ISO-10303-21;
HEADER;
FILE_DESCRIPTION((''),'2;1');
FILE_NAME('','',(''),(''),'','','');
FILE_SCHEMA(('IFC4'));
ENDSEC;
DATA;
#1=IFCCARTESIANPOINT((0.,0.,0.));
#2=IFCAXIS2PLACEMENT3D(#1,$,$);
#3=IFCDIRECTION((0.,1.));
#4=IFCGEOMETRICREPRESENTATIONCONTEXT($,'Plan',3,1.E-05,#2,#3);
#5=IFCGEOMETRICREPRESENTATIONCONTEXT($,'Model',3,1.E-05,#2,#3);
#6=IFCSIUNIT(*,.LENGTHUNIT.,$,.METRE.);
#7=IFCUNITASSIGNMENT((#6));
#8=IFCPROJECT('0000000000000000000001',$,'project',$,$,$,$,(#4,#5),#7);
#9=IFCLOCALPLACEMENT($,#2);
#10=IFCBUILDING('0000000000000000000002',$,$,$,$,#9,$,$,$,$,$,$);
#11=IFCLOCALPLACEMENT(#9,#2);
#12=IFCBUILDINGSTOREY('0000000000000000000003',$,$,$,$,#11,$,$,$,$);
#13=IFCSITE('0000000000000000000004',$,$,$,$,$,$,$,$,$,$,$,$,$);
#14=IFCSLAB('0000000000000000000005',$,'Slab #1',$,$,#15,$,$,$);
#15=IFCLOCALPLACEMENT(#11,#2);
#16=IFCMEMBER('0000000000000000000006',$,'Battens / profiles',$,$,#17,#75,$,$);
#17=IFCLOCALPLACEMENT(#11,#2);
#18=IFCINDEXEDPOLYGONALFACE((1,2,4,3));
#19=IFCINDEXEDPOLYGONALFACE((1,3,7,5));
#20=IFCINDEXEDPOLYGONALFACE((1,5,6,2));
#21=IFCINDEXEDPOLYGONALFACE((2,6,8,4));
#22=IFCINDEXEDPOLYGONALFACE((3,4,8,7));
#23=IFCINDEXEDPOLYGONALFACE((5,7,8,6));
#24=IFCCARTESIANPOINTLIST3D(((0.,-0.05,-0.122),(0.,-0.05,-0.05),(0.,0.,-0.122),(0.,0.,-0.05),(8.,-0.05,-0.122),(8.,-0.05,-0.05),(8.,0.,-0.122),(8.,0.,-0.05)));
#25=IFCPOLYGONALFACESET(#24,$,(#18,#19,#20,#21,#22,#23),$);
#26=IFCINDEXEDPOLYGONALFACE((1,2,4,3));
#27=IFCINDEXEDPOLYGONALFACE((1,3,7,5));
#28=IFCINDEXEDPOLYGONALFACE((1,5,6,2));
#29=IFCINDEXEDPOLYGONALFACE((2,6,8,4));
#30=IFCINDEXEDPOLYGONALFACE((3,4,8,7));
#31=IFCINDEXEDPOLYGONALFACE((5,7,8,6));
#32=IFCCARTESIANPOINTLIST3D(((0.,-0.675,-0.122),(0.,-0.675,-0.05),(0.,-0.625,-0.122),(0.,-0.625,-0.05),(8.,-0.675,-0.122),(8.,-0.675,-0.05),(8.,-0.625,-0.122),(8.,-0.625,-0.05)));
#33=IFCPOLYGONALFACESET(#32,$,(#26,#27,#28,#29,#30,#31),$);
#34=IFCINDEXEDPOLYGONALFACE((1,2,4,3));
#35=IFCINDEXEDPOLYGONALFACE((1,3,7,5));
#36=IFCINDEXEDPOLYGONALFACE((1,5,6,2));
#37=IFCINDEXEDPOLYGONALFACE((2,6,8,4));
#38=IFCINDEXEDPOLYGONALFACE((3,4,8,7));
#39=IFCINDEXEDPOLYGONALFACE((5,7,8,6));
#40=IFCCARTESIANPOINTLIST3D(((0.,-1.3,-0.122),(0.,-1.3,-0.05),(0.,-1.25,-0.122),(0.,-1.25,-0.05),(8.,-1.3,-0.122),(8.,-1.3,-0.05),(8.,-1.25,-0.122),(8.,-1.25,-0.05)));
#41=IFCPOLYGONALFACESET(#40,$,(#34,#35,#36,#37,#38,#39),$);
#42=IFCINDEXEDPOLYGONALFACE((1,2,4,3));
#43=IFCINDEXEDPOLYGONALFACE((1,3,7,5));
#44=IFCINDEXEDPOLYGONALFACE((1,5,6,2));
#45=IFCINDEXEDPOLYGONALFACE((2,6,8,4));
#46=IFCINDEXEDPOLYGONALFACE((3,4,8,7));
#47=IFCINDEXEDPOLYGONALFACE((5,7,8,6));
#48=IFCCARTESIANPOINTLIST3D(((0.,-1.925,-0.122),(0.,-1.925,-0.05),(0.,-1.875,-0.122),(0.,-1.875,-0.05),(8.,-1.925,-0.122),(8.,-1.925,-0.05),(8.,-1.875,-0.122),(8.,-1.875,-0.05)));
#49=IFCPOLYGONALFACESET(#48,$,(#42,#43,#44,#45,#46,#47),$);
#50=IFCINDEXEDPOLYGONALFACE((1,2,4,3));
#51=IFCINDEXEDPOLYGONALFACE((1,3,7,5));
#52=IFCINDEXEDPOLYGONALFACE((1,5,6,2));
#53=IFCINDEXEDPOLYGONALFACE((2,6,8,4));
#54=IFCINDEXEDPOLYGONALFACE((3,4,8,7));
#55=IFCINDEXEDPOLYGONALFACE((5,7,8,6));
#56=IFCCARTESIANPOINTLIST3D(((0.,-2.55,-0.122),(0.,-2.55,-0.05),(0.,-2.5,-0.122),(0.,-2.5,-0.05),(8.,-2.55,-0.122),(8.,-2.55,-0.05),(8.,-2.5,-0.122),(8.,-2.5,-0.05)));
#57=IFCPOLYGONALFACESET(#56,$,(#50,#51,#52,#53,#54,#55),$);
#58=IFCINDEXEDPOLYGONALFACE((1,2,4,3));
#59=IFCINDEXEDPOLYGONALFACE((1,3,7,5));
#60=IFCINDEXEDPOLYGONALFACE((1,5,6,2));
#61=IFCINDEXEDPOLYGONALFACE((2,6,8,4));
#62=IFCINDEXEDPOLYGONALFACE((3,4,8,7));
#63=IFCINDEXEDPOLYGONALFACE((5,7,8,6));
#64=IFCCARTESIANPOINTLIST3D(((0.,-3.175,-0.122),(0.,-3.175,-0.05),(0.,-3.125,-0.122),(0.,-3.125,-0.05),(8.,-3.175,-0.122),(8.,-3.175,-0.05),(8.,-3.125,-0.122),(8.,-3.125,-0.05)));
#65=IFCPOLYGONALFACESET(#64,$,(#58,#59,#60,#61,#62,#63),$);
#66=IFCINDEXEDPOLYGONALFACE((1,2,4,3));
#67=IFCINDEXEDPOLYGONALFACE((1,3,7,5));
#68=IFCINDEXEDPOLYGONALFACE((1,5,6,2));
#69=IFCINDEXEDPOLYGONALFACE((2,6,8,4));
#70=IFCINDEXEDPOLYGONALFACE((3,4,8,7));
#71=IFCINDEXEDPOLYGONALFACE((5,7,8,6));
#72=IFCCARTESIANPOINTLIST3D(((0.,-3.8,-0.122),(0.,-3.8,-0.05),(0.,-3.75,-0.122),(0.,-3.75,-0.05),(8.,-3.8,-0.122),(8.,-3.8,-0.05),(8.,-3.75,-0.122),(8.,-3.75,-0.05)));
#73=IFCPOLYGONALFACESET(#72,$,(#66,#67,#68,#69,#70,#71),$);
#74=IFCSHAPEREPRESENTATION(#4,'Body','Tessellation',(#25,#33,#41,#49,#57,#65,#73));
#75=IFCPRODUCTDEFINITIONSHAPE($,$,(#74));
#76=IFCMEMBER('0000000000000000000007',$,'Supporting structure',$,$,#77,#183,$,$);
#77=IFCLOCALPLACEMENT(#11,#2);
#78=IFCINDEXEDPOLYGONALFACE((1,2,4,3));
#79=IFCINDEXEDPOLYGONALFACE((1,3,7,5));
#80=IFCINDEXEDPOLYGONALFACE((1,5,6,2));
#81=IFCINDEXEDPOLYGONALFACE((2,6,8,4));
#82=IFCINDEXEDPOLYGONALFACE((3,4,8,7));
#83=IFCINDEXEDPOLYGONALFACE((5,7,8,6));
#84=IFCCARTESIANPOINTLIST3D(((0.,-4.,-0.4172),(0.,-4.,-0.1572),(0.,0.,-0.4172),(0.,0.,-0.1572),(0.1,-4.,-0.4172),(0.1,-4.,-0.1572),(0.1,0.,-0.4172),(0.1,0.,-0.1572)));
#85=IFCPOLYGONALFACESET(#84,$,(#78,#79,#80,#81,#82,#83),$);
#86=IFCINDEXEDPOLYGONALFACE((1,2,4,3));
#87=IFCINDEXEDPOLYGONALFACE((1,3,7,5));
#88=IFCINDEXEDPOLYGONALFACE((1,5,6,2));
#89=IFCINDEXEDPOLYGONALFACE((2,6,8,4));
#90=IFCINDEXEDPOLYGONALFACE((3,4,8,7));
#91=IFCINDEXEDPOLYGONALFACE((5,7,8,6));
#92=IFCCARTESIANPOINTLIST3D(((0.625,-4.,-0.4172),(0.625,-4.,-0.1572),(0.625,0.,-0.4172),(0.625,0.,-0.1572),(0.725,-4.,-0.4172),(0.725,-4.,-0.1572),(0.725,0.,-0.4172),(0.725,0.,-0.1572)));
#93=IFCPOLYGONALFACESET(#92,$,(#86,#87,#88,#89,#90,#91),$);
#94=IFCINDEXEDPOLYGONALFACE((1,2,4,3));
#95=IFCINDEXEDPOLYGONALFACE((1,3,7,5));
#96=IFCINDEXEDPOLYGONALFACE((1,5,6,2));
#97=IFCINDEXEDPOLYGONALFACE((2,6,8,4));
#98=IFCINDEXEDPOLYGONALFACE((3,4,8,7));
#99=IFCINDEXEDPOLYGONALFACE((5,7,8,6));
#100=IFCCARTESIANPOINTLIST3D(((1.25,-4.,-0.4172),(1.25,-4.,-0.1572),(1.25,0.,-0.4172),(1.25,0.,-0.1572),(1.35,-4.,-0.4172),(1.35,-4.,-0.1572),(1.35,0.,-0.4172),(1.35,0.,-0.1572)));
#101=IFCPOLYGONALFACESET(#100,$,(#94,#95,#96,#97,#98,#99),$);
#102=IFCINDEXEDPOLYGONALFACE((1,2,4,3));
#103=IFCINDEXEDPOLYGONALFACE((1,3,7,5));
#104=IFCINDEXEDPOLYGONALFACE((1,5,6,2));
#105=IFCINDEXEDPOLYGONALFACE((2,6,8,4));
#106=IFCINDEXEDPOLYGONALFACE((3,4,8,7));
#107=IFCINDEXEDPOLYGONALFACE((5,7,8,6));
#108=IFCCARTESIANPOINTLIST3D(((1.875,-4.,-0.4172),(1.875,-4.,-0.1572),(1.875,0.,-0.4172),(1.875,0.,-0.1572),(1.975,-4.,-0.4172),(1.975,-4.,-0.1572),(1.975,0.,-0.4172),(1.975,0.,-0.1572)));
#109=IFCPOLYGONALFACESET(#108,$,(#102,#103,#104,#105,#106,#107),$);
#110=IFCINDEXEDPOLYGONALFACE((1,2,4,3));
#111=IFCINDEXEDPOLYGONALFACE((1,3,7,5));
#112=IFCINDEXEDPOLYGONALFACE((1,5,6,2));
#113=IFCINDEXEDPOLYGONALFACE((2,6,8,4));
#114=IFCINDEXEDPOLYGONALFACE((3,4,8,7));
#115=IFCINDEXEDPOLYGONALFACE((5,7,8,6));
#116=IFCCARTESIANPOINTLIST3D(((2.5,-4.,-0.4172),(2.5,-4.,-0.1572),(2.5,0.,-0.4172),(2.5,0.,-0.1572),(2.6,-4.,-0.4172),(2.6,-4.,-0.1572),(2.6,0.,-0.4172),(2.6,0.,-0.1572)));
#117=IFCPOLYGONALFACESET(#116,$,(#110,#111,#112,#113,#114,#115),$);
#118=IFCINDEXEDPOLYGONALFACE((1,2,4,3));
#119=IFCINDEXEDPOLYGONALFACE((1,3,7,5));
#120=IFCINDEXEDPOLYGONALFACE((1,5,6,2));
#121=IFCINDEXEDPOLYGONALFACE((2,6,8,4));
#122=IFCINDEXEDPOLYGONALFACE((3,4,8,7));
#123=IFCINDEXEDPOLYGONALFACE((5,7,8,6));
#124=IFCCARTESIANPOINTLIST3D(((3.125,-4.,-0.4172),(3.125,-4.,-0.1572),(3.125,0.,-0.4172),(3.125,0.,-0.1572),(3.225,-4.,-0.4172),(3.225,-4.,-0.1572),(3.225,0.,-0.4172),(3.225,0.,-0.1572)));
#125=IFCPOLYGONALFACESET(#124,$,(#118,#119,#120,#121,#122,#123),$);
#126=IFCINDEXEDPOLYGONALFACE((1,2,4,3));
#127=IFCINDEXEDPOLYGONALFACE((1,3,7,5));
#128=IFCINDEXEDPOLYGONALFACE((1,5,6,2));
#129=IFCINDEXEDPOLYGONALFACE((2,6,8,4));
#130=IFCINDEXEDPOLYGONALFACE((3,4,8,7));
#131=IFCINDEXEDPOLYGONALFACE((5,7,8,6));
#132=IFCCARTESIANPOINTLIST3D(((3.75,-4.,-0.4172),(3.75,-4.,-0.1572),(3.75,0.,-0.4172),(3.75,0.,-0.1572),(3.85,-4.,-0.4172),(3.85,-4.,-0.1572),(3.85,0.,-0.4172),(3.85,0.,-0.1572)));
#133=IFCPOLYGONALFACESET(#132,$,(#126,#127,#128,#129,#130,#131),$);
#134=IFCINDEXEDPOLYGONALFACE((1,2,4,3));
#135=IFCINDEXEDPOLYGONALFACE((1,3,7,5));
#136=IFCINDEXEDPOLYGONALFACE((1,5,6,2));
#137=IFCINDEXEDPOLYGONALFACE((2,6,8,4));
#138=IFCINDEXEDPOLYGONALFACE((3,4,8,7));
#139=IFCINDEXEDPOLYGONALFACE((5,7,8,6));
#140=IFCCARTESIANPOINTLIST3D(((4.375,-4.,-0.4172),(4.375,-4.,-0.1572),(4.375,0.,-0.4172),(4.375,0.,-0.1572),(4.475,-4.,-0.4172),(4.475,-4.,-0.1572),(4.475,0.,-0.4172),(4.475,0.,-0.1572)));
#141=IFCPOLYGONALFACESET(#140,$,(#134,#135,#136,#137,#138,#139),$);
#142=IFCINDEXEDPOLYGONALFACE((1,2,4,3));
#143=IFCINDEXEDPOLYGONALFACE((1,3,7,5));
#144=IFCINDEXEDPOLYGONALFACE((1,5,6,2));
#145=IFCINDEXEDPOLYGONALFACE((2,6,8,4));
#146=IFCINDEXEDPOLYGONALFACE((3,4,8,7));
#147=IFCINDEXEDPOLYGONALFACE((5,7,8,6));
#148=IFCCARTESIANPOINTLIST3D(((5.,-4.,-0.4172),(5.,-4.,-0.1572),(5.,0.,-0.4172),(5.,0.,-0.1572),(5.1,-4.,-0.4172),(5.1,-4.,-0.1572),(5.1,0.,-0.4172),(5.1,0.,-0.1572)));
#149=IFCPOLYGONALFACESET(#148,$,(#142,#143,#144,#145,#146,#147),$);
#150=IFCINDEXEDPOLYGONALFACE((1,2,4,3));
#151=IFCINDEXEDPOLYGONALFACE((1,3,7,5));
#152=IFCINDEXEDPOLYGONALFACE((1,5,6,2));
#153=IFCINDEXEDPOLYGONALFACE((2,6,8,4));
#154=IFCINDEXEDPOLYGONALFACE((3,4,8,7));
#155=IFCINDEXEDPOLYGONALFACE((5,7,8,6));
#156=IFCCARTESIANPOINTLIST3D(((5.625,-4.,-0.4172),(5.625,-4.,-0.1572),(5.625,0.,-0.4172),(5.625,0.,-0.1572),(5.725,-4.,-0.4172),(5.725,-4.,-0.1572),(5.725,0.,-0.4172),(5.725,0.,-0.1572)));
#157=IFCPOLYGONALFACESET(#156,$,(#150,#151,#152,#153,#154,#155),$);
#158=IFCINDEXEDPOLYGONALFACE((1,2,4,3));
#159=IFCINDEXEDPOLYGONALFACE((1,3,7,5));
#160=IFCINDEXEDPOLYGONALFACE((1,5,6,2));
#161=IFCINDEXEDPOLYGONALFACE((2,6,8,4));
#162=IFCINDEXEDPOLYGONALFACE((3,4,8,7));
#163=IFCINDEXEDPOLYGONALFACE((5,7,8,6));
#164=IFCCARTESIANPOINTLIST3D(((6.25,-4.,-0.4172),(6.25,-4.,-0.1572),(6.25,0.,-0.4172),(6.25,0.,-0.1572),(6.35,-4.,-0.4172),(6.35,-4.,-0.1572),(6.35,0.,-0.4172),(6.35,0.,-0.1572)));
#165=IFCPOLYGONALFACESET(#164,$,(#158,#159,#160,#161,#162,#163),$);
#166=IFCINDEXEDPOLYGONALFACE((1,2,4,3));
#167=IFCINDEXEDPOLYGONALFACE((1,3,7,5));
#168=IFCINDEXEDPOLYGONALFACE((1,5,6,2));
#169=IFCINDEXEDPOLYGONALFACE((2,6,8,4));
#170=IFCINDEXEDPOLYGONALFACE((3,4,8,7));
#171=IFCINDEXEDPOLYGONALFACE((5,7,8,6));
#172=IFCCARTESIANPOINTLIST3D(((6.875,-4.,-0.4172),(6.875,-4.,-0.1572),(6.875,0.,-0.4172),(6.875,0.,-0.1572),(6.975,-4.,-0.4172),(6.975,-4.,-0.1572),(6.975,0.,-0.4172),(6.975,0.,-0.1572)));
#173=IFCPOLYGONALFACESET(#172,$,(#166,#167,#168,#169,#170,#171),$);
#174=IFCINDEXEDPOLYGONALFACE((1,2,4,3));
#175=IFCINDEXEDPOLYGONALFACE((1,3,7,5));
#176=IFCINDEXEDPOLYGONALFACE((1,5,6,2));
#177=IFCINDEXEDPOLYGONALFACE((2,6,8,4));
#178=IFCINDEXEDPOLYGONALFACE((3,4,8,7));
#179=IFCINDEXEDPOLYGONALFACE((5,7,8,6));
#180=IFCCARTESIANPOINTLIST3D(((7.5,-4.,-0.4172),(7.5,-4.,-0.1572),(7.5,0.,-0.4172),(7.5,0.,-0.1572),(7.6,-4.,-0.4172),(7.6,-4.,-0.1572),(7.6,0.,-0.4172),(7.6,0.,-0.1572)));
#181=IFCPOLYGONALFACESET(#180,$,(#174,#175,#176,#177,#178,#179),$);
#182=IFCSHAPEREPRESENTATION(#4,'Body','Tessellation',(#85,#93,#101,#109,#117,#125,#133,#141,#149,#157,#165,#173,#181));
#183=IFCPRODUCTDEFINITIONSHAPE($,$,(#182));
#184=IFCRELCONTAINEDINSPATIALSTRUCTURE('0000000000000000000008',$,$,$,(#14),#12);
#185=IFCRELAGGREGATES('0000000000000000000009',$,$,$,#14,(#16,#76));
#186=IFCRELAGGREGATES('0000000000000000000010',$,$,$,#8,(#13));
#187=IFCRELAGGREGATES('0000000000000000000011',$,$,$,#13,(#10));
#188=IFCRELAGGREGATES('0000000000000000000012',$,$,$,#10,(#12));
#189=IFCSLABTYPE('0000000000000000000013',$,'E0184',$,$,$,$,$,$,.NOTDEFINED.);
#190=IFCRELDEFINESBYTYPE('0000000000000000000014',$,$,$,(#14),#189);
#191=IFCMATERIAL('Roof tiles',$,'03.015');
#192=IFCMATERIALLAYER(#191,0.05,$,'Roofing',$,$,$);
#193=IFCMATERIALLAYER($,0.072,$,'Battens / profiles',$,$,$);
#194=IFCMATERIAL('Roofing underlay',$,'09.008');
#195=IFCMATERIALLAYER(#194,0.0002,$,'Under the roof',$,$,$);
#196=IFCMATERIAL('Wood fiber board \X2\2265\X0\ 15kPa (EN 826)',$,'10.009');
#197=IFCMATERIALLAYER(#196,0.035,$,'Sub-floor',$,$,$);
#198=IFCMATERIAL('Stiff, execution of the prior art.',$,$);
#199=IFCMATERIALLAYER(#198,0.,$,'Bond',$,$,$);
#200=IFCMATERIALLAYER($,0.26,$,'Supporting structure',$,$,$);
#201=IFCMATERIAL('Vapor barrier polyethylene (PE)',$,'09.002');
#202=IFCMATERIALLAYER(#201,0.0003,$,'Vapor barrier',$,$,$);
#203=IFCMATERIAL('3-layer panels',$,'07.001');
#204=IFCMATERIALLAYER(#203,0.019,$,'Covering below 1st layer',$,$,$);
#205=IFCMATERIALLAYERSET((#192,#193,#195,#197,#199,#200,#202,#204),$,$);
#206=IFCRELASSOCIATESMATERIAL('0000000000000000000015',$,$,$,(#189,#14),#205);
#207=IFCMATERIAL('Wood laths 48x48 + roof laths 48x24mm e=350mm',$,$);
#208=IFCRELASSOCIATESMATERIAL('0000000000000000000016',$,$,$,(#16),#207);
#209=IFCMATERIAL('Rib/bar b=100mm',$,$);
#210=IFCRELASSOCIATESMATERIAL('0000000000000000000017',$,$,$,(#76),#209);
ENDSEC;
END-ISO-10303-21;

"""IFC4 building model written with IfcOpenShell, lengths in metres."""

from ifc_helpers import new_model, si_unit, direction, frame, frame_2d, origin, place, context, project, spatial, rectangle, extrude, material, layer, layer_set, type_object, element, aggregate, save


model = new_model("IFC4")

# Units and contexts
plan_context = context("Plan", 3, precision=1e-05, world=origin(), true_north=direction((0.0, 1.0)))
model_context = context("Model", 3, precision=1e-05, world=origin(), true_north=direction((0.0, 1.0)))
ifc_project = project(units=[si_unit("LENGTHUNIT", "METRE")], contexts=[plan_context, model_context])

# Site, building, storey
site = spatial("IfcSite", under=ifc_project)
building_placement = place(None, origin())
building = spatial("IfcBuilding", under=site, at=building_placement)
storey_placement = place(building_placement, origin())
storey = spatial("IfcBuildingStorey", under=building, at=storey_placement)

# Slab, members
ifc_material_1 = material(Name="Roof tiles", Category="03.015")
ifc_layer_1 = layer(ifc_material_1, 0.05, Name="Roofing")
ifc_layer_2 = layer(None, 0.072, Name="Battens / profiles")
ifc_material_2 = material(Name="Roofing underlay", Category="09.008")
ifc_layer_3 = layer(ifc_material_2, 0.0002, Name="Under the roof")
ifc_material_3 = material(Name="Wood fiber board ≥ 15kPa (EN 826)", Category="10.009")
ifc_layer_4 = layer(ifc_material_3, 0.035, Name="Sub-floor")
ifc_material_4 = material(Name="Stiff, execution of the prior art.")
ifc_layer_5 = layer(ifc_material_4, 0.0, Name="Bond")
ifc_layer_6 = layer(None, 0.26, Name="Supporting structure")
ifc_material_5 = material(Name="Vapor barrier polyethylene (PE)", Category="09.002")
ifc_layer_7 = layer(ifc_material_5, 0.0003, Name="Vapor barrier")
ifc_material_6 = material(Name="3-layer panels", Category="07.001")
ifc_layer_8 = layer(ifc_material_6, 0.019, Name="Covering below 1st layer")
ifc_layer_set = layer_set([ifc_layer_1, ifc_layer_2, ifc_layer_3, ifc_layer_4, ifc_layer_5, ifc_layer_6, ifc_layer_7, ifc_layer_8])
slab_type = type_object("IfcSlabType", Name="E0184", PredefinedType="NOTDEFINED", material=ifc_layer_set)
slab_placement = place(None, frame((0.0, 0.0, 0.0), z_axis=(0.0, 0.0, -1.0), x_axis=(1.0, 0.0, 0.0)))
slab = element("IfcSlab", 1, at=slab_placement, inside=storey, type_object=slab_type, material=ifc_layer_set, Name="Slab #1")
ifc_material_7 = material(Name="Wood laths 48x48 + roof laths 48x24mm e=350mm")
member_1_placement = place(slab_placement, origin())
member_1 = element("IfcMember", 2, at=member_1_placement, material=ifc_material_7, Name="Battens / profiles", context=plan_context, shape_type="SweptSolid", body=[
    extrude(rectangle(XDim=0.05, YDim=0.072, at=frame_2d((0.025, 0.036), x_axis=(1.0, 0.0))), frame((0.0, 0.0, 0.05), z_axis=(1.0, 0.0, 0.0), x_axis=(0.0, 1.0, 0.0)), (0.0, 0.0, 1.0), 8.0),
    extrude(rectangle(XDim=0.05, YDim=0.072, at=frame_2d((0.025, 0.036), x_axis=(1.0, 0.0))), frame((0.0, 0.625, 0.05), z_axis=(1.0, 0.0, 0.0), x_axis=(0.0, 1.0, 0.0)), (0.0, 0.0, 1.0), 8.0),
    extrude(rectangle(XDim=0.05, YDim=0.072, at=frame_2d((0.025, 0.036), x_axis=(1.0, 0.0))), frame((0.0, 1.25, 0.05), z_axis=(1.0, 0.0, 0.0), x_axis=(0.0, 1.0, 0.0)), (0.0, 0.0, 1.0), 8.0),
    extrude(rectangle(XDim=0.05, YDim=0.072, at=frame_2d((0.025, 0.036), x_axis=(1.0, 0.0))), frame((0.0, 1.875, 0.05), z_axis=(1.0, 0.0, 0.0), x_axis=(0.0, 1.0, 0.0)), (0.0, 0.0, 1.0), 8.0),
    extrude(rectangle(XDim=0.05, YDim=0.072, at=frame_2d((0.025, 0.036), x_axis=(1.0, 0.0))), frame((0.0, 2.5, 0.05), z_axis=(1.0, 0.0, 0.0), x_axis=(0.0, 1.0, 0.0)), (0.0, 0.0, 1.0), 8.0),
    extrude(rectangle(XDim=0.05, YDim=0.072, at=frame_2d((0.025, 0.036), x_axis=(1.0, 0.0))), frame((0.0, 3.125, 0.05), z_axis=(1.0, 0.0, 0.0), x_axis=(0.0, 1.0, 0.0)), (0.0, 0.0, 1.0), 8.0),
    extrude(rectangle(XDim=0.05, YDim=0.072, at=frame_2d((0.025, 0.036), x_axis=(1.0, 0.0))), frame((0.0, 3.75, 0.05), z_axis=(1.0, 0.0, 0.0), x_axis=(0.0, 1.0, 0.0)), (0.0, 0.0, 1.0), 8.0),
])
ifc_material_8 = material(Name="Rib/bar b=100mm")
member_2_placement = place(slab_placement, origin())
member_2 = element("IfcMember", 3, at=member_2_placement, material=ifc_material_8, Name="Supporting structure", context=plan_context, shape_type="SweptSolid", body=[
    extrude(rectangle(XDim=0.1, YDim=0.26, at=frame_2d((0.05, 0.13), x_axis=(1.0, 0.0))), frame((0.0, 4.0, 0.1572), z_axis=(0.0, -1.0, 0.0), x_axis=(1.0, 0.0, 0.0)), (0.0, 0.0, 1.0), 4.0),
    extrude(rectangle(XDim=0.1, YDim=0.26, at=frame_2d((0.05, 0.13), x_axis=(1.0, 0.0))), frame((0.625, 4.0, 0.1572), z_axis=(0.0, -1.0, 0.0), x_axis=(1.0, 0.0, 0.0)), (0.0, 0.0, 1.0), 4.0),
    extrude(rectangle(XDim=0.1, YDim=0.26, at=frame_2d((0.05, 0.13), x_axis=(1.0, 0.0))), frame((1.25, 4.0, 0.1572), z_axis=(0.0, -1.0, 0.0), x_axis=(1.0, 0.0, 0.0)), (0.0, 0.0, 1.0), 4.0),
    extrude(rectangle(XDim=0.1, YDim=0.26, at=frame_2d((0.05, 0.13), x_axis=(1.0, 0.0))), frame((1.875, 4.0, 0.1572), z_axis=(0.0, -1.0, 0.0), x_axis=(1.0, 0.0, 0.0)), (0.0, 0.0, 1.0), 4.0),
    extrude(rectangle(XDim=0.1, YDim=0.26, at=frame_2d((0.05, 0.13), x_axis=(1.0, 0.0))), frame((2.5, 4.0, 0.1572), z_axis=(0.0, -1.0, 0.0), x_axis=(1.0, 0.0, 0.0)), (0.0, 0.0, 1.0), 4.0),
    extrude(rectangle(XDim=0.1, YDim=0.26, at=frame_2d((0.05, 0.13), x_axis=(1.0, 0.0))), frame((3.125, 4.0, 0.1572), z_axis=(0.0, -1.0, 0.0), x_axis=(1.0, 0.0, 0.0)), (0.0, 0.0, 1.0), 4.0),
    extrude(rectangle(XDim=0.1, YDim=0.26, at=frame_2d((0.05, 0.13), x_axis=(1.0, 0.0))), frame((3.75, 4.0, 0.1572), z_axis=(0.0, -1.0, 0.0), x_axis=(1.0, 0.0, 0.0)), (0.0, 0.0, 1.0), 4.0),
    extrude(rectangle(XDim=0.1, YDim=0.26, at=frame_2d((0.05, 0.13), x_axis=(1.0, 0.0))), frame((4.375, 4.0, 0.1572), z_axis=(0.0, -1.0, 0.0), x_axis=(1.0, 0.0, 0.0)), (0.0, 0.0, 1.0), 4.0),
    extrude(rectangle(XDim=0.1, YDim=0.26, at=frame_2d((0.05, 0.13), x_axis=(1.0, 0.0))), frame((5.0, 4.0, 0.1572), z_axis=(0.0, -1.0, 0.0), x_axis=(1.0, 0.0, 0.0)), (0.0, 0.0, 1.0), 4.0),
    extrude(rectangle(XDim=0.1, YDim=0.26, at=frame_2d((0.05, 0.13), x_axis=(1.0, 0.0))), frame((5.625, 4.0, 0.1572), z_axis=(0.0, -1.0, 0.0), x_axis=(1.0, 0.0, 0.0)), (0.0, 0.0, 1.0), 4.0),
    extrude(rectangle(XDim=0.1, YDim=0.26, at=frame_2d((0.05, 0.13), x_axis=(1.0, 0.0))), frame((6.25, 4.0, 0.1572), z_axis=(0.0, -1.0, 0.0), x_axis=(1.0, 0.0, 0.0)), (0.0, 0.0, 1.0), 4.0),
    extrude(rectangle(XDim=0.1, YDim=0.26, at=frame_2d((0.05, 0.13), x_axis=(1.0, 0.0))), frame((6.875, 4.0, 0.1572), z_axis=(0.0, -1.0, 0.0), x_axis=(1.0, 0.0, 0.0)), (0.0, 0.0, 1.0), 4.0),
    extrude(rectangle(XDim=0.1, YDim=0.26, at=frame_2d((0.05, 0.13), x_axis=(1.0, 0.0))), frame((7.5, 4.0, 0.1572), z_axis=(0.0, -1.0, 0.0), x_axis=(1.0, 0.0, 0.0)), (0.0, 0.0, 1.0), 4.0),
])
aggregate(slab, [member_1, member_2])

save(model, "model.ifc")
